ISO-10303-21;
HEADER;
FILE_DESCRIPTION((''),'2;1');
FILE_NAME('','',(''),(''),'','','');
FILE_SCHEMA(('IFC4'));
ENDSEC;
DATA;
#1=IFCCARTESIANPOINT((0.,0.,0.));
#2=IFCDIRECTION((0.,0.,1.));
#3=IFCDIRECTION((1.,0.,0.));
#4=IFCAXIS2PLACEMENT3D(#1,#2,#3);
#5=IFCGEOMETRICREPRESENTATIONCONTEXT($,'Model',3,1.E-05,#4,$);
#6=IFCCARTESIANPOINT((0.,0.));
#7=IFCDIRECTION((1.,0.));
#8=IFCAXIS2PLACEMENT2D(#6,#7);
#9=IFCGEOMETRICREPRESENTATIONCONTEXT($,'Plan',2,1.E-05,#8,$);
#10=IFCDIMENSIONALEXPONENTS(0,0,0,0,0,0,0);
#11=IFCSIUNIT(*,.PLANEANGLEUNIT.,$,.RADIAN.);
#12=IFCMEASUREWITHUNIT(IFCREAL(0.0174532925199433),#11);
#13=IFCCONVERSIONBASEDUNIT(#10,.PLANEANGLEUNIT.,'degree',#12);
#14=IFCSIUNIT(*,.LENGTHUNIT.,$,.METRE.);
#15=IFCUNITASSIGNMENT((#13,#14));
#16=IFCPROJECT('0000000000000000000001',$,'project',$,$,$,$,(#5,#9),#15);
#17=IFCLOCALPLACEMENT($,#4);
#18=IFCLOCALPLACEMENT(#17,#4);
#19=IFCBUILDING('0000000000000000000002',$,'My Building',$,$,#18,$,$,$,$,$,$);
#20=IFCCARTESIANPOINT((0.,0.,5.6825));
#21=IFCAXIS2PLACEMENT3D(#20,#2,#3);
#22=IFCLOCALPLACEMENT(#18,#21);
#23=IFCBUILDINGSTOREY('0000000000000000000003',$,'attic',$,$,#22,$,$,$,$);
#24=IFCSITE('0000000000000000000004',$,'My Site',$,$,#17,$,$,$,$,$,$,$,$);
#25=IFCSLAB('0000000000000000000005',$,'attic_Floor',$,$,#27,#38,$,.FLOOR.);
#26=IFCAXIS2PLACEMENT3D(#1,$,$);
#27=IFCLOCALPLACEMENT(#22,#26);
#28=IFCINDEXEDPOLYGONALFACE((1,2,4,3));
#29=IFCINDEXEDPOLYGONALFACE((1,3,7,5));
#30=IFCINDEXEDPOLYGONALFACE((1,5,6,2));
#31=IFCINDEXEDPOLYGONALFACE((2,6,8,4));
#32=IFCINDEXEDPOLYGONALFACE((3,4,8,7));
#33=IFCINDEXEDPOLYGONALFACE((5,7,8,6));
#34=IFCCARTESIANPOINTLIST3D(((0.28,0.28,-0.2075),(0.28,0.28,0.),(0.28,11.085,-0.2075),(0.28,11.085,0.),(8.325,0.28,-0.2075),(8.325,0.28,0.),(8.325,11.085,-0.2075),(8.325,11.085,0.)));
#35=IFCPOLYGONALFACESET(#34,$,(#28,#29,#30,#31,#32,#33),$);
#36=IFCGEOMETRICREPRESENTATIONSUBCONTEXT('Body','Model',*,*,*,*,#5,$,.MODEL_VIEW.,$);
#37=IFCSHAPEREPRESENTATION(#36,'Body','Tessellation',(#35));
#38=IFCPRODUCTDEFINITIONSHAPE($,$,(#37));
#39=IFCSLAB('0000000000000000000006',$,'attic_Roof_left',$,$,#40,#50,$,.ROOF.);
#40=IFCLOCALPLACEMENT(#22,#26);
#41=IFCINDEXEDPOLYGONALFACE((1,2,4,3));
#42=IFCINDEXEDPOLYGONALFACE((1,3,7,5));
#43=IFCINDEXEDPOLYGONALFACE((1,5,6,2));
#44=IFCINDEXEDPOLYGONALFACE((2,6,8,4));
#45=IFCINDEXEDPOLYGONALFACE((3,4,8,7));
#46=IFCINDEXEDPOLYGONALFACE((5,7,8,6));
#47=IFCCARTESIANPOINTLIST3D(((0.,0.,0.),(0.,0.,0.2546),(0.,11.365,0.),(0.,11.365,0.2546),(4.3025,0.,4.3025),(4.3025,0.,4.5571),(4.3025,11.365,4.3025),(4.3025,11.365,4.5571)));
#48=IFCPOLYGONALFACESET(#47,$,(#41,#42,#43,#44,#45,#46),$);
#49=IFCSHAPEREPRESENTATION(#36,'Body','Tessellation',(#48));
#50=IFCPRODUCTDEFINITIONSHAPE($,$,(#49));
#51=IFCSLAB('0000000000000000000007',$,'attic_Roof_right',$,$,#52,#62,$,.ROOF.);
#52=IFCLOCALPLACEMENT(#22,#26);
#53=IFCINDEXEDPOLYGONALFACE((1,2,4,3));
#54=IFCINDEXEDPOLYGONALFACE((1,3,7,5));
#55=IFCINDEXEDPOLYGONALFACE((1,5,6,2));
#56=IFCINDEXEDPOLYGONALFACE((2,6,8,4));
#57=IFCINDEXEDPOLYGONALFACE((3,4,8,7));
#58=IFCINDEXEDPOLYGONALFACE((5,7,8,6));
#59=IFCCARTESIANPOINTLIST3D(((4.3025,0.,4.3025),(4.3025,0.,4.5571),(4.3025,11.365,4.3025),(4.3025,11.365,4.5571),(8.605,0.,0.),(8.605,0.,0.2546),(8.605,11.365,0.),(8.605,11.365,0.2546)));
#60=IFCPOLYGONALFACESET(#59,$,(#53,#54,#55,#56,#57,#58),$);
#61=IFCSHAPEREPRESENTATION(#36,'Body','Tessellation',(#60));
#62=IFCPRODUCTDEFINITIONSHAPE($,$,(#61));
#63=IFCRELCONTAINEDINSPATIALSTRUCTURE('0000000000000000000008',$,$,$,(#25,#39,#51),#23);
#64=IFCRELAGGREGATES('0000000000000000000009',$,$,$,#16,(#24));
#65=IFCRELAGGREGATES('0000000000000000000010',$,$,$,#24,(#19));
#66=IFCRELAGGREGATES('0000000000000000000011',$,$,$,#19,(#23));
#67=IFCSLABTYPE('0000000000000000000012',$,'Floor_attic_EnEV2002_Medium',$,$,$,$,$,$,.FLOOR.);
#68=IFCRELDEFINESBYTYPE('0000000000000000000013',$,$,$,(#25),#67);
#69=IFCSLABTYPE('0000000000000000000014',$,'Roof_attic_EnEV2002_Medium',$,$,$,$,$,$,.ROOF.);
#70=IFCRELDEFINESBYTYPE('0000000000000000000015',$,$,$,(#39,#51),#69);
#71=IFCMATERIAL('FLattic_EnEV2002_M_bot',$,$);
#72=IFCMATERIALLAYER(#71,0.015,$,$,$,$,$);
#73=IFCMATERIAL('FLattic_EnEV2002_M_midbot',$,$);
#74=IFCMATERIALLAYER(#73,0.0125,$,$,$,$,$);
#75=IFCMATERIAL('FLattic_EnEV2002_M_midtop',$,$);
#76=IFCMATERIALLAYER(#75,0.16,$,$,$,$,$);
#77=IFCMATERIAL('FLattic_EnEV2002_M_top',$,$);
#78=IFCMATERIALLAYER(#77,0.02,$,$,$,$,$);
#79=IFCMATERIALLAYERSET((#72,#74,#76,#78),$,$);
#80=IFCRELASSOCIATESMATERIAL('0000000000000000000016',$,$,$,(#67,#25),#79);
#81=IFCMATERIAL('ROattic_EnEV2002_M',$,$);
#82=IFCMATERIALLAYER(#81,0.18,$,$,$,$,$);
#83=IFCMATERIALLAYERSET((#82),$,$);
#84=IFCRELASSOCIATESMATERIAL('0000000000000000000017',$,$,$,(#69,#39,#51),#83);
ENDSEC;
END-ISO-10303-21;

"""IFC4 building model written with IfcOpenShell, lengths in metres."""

from ifc_helpers import new_model, entity, si_unit, converted_unit, frame, origin_with_axes, origin_2d_with_axis, place, context, subcontext, project, spatial, line, indexed_curve, outline, extrude, material, layer, layer_set, layer_usage, type_object, element, save


model = new_model("IFC4")

# Units and contexts
model_context = context("Model", 3, precision=1e-05, world=origin_with_axes())
plan_context = context("Plan", 2, precision=1e-05, world=origin_2d_with_axis())
body_context = subcontext(model_context, "Body", "Model", "MODEL_VIEW")
ifc_project = project(units=[converted_unit("PLANEANGLEUNIT", "degree", entity("IfcReal", 0.0174532925199433), si_unit("PLANEANGLEUNIT", "RADIAN"), dimensions=[0, 0, 0, 0, 0, 0, 0]), si_unit("LENGTHUNIT", "METRE")], contexts=[model_context, plan_context])

# Site, building, storey
site_placement = place(None, origin_with_axes())
site = spatial("IfcSite", under=ifc_project, at=site_placement, Name="My Site")
building_placement = place(site_placement, origin_with_axes())
building = spatial("IfcBuilding", under=site, at=building_placement, Name="My Building")
storey_placement = place(building_placement, frame((0.0, 0.0, 5.6825), z_axis=(0.0, 0.0, 1.0), x_axis=(1.0, 0.0, 0.0)))
storey = spatial("IfcBuildingStorey", under=building, at=storey_placement, Name="attic")

# Slabs
ifc_material_1 = material(Name="FLattic_EnEV2002_M_bot")
ifc_layer_1 = layer(ifc_material_1, 0.015)
ifc_material_2 = material(Name="FLattic_EnEV2002_M_midbot")
ifc_layer_2 = layer(ifc_material_2, 0.0125)
ifc_material_3 = material(Name="FLattic_EnEV2002_M_midtop")
ifc_layer_3 = layer(ifc_material_3, 0.16)
ifc_material_4 = material(Name="FLattic_EnEV2002_M_top")
ifc_layer_4 = layer(ifc_material_4, 0.02)
ifc_layer_set_1 = layer_set([ifc_layer_1, ifc_layer_2, ifc_layer_3, ifc_layer_4])
ifc_layer_usage_1 = layer_usage(ifc_layer_set_1, "AXIS3", "POSITIVE", 0.0)
slab_type_1 = type_object("IfcSlabType", Name="Floor_attic_EnEV2002_Medium", PredefinedType="FLOOR", material=ifc_layer_set_1)
slab_1_placement = place(storey_placement, frame((0.28, 0.28, -0.2075), z_axis=(0.0, 0.0, 1.0), x_axis=(1.0, 0.0, 0.0)))
element("IfcSlab", 1, at=slab_1_placement, inside=storey, type_object=slab_type_1, material=ifc_layer_usage_1, Name="attic_Floor", PredefinedType="FLOOR", context=body_context, shape_type="SweptSolid", body=[
    extrude(outline(indexed_curve([(0.0, 0.0), (8.045, 0.0), (8.045, 10.805), (0.0, 10.805)], segments=[line(4, 1), line(1, 2), line(2, 3), line(3, 4)], self_intersect=False)), None, (0.0, 0.0, 1.0), 0.2075),
])
ifc_material_5 = material(Name="ROattic_EnEV2002_M")
ifc_layer_5 = layer(ifc_material_5, 0.18)
ifc_layer_set_2 = layer_set([ifc_layer_5])
ifc_layer_usage_2 = layer_usage(ifc_layer_set_2, "AXIS3", "POSITIVE", 0.0)
slab_type_2 = type_object("IfcSlabType", Name="Roof_attic_EnEV2002_Medium", PredefinedType="ROOF", material=ifc_layer_set_2)
slab_2_placement = place(storey_placement, frame((0.0, 11.365, 0.0), z_axis=(-0.707107, 0.0, 0.707107), x_axis=(0.0, -1.0, 0.0)))
element("IfcSlab", 2, at=slab_2_placement, inside=storey, type_object=slab_type_2, material=ifc_layer_usage_2, Name="attic_Roof_left", PredefinedType="ROOF", context=body_context, shape_type="SweptSolid", body=[
    extrude(outline(indexed_curve([(11.365, 0.0), (0.0, 0.0), (0.0, 6.0846), (11.365, 6.0847)], segments=[line(4, 1), line(1, 2), line(2, 3), line(3, 4)], self_intersect=False)), None, (0.0, 0.707107, 0.707107), 0.2546),
])
ifc_layer_usage_3 = layer_usage(ifc_layer_set_2, "AXIS3", "POSITIVE", 0.0)
slab_3_placement = place(storey_placement, frame((8.605, 0.0, 0.0), z_axis=(0.707107, 0.0, 0.707107), x_axis=(0.0, 1.0, 0.0)))
element("IfcSlab", 3, at=slab_3_placement, inside=storey, type_object=slab_type_2, material=ifc_layer_usage_3, Name="attic_Roof_right", PredefinedType="ROOF", context=body_context, shape_type="SweptSolid", body=[
    extrude(outline(indexed_curve([(0.0, 6.0847), (0.0, 0.0), (11.365, 0.0), (11.365, 6.0847)], segments=[line(3, 2), line(2, 1), line(1, 4), line(4, 3)], self_intersect=False)), None, (0.0, 0.707107, 0.707107), 0.2546),
])

save(model, "model.ifc")
